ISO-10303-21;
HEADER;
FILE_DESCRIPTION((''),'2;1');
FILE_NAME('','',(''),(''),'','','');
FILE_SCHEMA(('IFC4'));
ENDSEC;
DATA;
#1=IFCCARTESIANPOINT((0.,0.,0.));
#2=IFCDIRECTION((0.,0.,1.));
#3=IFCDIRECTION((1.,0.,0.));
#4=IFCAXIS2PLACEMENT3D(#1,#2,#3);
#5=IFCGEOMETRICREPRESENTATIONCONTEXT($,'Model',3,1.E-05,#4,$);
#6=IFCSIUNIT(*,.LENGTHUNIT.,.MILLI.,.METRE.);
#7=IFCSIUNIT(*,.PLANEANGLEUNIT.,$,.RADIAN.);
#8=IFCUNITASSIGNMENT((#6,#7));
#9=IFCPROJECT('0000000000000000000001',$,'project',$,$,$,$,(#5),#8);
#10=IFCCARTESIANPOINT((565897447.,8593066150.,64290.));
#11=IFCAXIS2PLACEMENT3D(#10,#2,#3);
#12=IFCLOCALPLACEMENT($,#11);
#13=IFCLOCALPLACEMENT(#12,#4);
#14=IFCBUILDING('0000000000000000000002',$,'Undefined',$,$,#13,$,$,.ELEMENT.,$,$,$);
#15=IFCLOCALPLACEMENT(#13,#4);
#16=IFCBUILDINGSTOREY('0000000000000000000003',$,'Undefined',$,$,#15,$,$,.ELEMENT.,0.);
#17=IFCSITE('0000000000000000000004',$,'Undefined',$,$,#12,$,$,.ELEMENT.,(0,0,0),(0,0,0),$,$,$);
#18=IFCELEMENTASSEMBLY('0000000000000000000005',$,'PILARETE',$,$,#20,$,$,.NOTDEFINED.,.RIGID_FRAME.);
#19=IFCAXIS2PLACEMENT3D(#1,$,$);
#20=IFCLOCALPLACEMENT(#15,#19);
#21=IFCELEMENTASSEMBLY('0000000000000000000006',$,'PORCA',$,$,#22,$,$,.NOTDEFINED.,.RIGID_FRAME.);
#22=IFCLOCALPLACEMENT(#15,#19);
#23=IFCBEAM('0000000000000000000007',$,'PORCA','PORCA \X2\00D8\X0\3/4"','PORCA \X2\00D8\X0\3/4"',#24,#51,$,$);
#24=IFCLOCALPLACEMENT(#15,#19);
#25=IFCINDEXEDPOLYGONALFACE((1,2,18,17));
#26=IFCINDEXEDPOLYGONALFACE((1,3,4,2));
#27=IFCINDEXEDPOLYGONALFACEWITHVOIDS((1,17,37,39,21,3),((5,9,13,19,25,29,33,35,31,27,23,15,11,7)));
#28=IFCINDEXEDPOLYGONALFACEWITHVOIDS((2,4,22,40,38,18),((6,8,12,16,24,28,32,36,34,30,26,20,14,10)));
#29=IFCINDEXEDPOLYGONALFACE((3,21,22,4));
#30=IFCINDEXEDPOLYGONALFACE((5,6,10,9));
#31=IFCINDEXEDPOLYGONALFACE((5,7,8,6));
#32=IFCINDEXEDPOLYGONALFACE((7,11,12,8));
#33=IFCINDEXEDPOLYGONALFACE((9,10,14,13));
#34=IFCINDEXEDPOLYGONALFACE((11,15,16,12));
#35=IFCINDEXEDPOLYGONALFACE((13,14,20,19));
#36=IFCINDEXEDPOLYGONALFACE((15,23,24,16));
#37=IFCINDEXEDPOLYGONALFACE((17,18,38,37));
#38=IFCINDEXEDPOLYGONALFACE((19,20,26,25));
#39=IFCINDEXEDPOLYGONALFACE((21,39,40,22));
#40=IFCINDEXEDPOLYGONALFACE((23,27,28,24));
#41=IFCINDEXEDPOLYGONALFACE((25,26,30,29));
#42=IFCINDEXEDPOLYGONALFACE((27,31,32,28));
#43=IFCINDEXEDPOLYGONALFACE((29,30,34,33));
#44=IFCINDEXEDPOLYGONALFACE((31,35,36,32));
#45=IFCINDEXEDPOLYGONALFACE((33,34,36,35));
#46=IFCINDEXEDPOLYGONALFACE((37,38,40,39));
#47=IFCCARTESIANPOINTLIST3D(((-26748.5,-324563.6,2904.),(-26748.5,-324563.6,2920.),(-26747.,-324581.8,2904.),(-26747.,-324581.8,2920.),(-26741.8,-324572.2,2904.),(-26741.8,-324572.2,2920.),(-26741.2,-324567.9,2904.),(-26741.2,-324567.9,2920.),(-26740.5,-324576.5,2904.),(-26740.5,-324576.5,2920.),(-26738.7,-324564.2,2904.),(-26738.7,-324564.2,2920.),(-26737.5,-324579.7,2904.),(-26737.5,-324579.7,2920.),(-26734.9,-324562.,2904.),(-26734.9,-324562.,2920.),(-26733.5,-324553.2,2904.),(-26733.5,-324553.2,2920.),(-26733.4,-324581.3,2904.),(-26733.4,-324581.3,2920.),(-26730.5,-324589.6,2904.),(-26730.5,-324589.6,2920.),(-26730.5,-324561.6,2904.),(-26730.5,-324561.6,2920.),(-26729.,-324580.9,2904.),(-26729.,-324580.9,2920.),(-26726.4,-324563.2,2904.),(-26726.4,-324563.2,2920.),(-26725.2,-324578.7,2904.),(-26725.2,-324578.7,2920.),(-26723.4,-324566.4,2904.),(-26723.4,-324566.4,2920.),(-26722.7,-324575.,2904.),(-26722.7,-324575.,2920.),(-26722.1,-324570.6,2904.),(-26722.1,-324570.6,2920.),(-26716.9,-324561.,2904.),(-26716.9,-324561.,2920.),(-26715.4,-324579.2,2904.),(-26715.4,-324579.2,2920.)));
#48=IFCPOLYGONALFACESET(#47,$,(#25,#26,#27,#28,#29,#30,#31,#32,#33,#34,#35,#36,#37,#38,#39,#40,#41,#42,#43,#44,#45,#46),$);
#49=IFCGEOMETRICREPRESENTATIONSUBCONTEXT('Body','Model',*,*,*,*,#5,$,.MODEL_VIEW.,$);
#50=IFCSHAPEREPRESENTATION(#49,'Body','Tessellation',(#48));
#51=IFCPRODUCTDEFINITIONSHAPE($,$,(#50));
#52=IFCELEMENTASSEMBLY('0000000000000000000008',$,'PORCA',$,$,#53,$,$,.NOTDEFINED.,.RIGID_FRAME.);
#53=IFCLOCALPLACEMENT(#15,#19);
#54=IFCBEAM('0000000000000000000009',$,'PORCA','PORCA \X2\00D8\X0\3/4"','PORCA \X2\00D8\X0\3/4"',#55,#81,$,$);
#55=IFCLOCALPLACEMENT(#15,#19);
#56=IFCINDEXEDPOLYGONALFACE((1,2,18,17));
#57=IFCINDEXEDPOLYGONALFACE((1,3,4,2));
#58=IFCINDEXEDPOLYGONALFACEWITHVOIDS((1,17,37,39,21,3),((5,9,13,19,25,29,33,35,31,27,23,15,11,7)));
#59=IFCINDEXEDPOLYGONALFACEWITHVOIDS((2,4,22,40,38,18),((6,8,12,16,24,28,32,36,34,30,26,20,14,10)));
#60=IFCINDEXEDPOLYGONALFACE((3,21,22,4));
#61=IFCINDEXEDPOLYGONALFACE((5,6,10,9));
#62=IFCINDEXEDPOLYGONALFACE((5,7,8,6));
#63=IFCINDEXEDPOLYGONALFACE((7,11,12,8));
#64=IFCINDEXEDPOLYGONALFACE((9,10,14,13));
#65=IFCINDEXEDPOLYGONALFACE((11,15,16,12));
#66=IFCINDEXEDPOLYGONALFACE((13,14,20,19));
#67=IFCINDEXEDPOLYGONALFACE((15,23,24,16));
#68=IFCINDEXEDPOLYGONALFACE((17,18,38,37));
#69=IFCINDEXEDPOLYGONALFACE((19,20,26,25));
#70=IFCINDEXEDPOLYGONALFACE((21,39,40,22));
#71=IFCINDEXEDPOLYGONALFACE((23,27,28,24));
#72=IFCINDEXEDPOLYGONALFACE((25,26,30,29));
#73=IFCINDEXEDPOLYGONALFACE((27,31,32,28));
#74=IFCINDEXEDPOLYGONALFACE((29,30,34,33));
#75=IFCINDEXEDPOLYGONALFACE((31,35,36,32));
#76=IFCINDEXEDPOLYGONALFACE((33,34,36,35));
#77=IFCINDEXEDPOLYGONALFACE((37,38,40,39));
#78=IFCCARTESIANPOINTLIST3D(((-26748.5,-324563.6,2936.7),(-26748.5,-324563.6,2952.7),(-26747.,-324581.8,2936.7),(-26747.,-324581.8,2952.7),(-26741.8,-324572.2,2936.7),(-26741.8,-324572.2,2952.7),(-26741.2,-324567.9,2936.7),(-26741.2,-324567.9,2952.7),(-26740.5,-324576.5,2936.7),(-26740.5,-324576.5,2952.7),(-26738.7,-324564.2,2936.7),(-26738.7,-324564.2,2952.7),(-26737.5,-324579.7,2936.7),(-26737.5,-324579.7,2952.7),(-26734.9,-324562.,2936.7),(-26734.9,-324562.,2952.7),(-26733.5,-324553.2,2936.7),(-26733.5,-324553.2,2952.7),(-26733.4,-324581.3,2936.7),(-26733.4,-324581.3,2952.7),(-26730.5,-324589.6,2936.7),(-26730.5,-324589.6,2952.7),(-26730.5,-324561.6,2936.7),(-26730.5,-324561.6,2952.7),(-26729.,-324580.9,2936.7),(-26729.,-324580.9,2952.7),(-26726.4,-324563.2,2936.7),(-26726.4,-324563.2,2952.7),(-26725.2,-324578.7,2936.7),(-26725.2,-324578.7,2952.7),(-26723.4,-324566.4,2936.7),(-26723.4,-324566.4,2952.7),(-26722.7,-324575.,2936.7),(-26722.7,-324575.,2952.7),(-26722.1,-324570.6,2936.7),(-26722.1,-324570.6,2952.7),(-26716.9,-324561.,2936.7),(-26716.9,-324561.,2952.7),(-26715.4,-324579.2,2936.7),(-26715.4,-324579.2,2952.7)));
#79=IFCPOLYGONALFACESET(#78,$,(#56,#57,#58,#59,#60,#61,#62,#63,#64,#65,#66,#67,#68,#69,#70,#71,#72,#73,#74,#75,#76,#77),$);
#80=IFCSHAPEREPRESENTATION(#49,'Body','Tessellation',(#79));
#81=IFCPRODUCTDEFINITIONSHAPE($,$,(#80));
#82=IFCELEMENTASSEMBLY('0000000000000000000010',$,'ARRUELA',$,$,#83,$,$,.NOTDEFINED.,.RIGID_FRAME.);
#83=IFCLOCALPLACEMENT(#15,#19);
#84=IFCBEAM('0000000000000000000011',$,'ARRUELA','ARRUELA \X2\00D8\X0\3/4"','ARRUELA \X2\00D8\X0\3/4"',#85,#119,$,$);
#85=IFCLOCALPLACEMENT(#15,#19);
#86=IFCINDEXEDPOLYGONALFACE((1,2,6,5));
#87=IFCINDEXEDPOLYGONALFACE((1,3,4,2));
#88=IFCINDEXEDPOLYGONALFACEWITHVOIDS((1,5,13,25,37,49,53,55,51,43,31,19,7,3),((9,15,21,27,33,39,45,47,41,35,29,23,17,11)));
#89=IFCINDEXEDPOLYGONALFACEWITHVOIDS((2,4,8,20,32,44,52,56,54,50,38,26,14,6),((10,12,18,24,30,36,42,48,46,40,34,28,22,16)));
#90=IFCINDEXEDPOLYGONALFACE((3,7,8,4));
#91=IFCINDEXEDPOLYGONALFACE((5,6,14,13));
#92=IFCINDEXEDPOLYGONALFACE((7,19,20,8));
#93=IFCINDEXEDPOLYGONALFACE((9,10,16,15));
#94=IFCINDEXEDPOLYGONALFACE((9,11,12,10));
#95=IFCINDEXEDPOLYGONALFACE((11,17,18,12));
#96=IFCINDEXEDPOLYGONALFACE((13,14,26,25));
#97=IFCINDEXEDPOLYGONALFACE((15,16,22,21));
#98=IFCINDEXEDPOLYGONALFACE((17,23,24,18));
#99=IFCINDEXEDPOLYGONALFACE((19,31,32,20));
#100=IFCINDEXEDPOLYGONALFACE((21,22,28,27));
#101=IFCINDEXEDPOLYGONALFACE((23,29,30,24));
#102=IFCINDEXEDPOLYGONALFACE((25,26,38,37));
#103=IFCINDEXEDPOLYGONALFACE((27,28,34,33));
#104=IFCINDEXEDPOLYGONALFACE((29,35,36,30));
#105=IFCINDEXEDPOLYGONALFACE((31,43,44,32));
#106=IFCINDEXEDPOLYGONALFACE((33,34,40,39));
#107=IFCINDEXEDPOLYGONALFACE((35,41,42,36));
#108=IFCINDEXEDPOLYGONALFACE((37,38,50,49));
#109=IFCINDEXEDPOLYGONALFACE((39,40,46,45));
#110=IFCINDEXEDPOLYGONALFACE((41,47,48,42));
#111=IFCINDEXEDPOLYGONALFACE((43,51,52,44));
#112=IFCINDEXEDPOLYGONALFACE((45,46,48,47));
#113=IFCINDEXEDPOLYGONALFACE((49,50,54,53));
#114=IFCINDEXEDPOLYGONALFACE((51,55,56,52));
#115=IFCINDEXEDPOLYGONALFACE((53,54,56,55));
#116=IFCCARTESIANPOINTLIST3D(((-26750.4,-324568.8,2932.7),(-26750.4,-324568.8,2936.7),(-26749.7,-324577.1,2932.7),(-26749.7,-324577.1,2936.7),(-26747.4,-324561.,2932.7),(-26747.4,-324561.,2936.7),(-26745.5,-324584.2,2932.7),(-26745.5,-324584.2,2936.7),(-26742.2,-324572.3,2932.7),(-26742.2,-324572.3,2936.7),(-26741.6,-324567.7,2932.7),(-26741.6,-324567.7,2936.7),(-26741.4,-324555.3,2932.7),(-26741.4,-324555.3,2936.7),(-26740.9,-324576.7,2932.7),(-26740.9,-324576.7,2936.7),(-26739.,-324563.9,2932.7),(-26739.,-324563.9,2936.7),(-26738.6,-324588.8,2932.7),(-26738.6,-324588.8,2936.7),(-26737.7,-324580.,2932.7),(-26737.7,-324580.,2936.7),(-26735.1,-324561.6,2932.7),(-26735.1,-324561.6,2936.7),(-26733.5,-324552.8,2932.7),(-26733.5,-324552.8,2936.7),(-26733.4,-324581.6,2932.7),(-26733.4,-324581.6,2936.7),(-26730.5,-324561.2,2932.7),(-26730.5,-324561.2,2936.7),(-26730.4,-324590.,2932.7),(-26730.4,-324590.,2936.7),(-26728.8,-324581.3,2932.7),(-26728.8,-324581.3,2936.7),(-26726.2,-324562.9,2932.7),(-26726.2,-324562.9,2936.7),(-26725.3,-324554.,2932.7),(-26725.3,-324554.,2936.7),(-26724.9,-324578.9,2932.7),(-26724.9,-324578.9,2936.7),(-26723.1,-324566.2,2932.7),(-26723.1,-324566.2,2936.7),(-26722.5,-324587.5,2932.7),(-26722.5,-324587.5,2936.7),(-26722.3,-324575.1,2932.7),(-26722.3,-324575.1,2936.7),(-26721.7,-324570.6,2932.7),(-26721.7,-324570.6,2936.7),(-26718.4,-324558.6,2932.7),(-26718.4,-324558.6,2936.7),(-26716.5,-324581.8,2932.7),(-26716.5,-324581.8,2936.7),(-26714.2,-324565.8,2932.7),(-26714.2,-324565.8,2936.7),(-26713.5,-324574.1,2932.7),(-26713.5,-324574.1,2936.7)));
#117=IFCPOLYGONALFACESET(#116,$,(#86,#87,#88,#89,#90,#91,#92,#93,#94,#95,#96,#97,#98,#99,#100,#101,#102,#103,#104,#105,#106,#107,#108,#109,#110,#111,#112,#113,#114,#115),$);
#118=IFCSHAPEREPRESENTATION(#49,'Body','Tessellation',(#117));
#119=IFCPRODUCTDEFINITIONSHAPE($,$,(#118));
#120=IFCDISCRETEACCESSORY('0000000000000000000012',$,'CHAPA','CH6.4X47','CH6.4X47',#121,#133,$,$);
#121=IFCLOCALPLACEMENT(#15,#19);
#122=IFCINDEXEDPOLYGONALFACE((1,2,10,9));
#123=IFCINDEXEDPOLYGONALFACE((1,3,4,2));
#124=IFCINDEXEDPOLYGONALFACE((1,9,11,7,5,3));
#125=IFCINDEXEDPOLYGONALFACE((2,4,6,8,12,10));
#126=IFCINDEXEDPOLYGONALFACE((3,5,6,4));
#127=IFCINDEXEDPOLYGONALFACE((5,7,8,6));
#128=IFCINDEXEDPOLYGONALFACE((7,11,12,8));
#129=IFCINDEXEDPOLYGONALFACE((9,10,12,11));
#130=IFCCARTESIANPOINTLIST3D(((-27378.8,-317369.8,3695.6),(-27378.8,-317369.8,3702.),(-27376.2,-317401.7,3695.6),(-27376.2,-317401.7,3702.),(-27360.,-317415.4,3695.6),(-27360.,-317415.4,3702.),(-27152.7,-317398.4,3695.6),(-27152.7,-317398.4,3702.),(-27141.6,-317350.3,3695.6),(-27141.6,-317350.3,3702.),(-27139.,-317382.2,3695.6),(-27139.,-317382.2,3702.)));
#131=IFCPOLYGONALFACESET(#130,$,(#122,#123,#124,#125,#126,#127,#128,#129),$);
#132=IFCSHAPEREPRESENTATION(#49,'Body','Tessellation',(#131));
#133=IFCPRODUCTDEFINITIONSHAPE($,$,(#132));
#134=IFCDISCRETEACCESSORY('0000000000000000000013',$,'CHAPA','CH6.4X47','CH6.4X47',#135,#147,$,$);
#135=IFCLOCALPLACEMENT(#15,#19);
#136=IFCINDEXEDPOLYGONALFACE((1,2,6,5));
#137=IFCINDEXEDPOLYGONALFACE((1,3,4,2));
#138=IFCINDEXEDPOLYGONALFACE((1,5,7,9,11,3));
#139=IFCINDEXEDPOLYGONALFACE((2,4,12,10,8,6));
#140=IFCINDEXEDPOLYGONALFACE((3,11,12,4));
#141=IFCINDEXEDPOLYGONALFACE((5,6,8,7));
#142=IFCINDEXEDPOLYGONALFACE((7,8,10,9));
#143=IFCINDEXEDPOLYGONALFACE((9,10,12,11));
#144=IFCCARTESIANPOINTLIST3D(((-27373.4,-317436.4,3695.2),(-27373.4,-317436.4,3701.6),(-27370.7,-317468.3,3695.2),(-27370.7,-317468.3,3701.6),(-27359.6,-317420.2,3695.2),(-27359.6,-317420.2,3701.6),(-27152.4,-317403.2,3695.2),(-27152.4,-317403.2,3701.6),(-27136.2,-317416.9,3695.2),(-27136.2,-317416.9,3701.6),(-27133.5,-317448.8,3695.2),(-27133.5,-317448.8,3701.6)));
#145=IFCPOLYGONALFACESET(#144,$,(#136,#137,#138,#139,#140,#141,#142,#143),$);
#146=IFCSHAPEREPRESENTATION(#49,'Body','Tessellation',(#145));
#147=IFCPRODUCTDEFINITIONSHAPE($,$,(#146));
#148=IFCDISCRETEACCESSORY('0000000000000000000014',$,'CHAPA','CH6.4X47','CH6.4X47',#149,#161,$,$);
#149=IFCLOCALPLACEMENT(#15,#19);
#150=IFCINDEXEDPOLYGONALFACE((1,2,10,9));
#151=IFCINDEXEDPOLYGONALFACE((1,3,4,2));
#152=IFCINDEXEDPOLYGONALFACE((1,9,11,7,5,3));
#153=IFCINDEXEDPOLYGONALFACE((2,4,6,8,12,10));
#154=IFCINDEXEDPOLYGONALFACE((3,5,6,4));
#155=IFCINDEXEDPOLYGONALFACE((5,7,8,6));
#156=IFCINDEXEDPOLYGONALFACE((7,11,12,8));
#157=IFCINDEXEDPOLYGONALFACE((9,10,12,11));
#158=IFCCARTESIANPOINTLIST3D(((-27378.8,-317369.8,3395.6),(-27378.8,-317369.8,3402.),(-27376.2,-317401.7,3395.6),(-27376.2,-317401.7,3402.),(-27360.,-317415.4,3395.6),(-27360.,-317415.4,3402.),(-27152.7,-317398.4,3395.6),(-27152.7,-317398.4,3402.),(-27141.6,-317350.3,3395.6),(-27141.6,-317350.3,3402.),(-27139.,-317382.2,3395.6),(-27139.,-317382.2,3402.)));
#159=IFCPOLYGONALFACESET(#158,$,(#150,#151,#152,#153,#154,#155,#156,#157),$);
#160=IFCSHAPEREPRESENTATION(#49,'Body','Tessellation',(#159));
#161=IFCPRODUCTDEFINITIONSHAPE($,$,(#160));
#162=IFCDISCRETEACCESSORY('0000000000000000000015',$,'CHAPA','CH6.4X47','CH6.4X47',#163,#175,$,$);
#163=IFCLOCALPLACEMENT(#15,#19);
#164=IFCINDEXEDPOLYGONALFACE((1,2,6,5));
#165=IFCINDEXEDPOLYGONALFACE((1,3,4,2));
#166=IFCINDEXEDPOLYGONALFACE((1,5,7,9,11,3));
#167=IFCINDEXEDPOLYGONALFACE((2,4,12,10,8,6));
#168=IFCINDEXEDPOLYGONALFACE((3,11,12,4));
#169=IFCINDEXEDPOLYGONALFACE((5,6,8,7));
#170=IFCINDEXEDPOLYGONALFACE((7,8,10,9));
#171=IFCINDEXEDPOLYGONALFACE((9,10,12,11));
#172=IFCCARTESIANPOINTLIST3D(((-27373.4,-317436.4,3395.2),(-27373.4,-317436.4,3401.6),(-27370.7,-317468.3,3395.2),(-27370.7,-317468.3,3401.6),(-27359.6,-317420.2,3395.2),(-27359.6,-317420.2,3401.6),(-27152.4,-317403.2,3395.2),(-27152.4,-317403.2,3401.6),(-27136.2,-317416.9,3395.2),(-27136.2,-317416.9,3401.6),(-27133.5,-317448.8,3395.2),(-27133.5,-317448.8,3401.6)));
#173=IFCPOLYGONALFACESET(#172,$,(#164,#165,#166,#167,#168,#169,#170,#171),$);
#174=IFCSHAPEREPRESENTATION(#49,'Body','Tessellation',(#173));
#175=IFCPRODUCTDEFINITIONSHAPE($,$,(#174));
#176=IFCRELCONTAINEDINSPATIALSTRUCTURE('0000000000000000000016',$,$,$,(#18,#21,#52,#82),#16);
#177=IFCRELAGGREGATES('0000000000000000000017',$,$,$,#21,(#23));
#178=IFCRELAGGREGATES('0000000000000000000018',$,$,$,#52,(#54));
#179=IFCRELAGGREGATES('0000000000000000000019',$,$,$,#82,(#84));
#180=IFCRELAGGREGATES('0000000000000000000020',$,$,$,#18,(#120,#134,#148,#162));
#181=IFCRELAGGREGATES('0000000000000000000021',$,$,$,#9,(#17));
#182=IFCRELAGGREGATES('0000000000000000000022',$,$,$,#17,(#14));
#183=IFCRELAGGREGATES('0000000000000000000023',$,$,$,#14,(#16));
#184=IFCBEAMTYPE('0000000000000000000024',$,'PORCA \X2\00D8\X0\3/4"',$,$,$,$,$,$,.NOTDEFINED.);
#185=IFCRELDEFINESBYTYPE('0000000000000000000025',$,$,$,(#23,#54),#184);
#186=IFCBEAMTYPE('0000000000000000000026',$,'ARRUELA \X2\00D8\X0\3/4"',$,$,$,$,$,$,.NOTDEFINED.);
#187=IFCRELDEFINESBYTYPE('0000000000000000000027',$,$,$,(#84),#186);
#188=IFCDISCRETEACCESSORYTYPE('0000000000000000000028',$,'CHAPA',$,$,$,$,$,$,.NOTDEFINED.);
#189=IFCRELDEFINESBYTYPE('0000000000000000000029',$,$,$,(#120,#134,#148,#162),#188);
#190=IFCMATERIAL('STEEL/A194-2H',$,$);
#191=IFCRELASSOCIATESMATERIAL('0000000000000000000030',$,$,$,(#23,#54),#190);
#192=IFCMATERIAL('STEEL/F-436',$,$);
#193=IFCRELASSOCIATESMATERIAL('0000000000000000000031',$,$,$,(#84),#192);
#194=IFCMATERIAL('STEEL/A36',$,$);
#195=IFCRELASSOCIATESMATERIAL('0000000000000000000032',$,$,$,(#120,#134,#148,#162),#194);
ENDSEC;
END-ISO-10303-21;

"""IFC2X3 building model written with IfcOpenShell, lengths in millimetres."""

from ifc_helpers import new_model, si_unit, frame, origin_with_axes, place, context, subcontext, project, spatial, polyline, outline, extrude, material, type_object, element, aggregate, save


model = new_model("IFC2X3")

# Units and contexts
model_context = context("Model", 3, precision=1e-05, world=origin_with_axes())
body_context = subcontext(model_context, "Body", "Model", "MODEL_VIEW")
ifc_project = project(units=[si_unit("LENGTHUNIT", "METRE", prefix="MILLI"), si_unit("PLANEANGLEUNIT", "RADIAN")], contexts=[model_context])

# Site, building, storey
site_placement = place(None, frame((565897447.0, 8593066150.0, 64290.0), z_axis=(0.0, 0.0, 1.0), x_axis=(1.0, 0.0, 0.0)))
site = spatial("IfcSite", under=ifc_project, at=site_placement, Name="Undefined", CompositionType="ELEMENT", RefLatitude=(0, 0, 0), RefLongitude=(0, 0, 0))
building_placement = place(site_placement, origin_with_axes())
building = spatial("IfcBuilding", under=site, at=building_placement, Name="Undefined", CompositionType="ELEMENT")
storey_placement = place(building_placement, origin_with_axes())
storey = spatial("IfcBuildingStorey", under=building, at=storey_placement, Name="Undefined", CompositionType="ELEMENT", Elevation=0.0)

# Element assembly
assembly_1_placement = place(storey_placement, origin_with_axes())
assembly_1 = element("IfcElementAssembly", 1, at=assembly_1_placement, inside=storey, Name="PILARETE", AssemblyPlace="NOTDEFINED", PredefinedType="RIGID_FRAME")

# Element assemblies, beams
ifc_material_1 = material(Name="STEEL/A36")
assembly_2_placement = place(storey_placement, origin_with_axes())
assembly_2 = element("IfcElementAssembly", 2, at=assembly_2_placement, inside=storey, Name="PORCA", AssemblyPlace="NOTDEFINED", PredefinedType="RIGID_FRAME")
ifc_material_2 = material(Name="STEEL/A194-2H")
beam_type_1 = type_object("IfcBeamType", Name="PORCA Ø3/4\"", PredefinedType="NOTDEFINED")
beam_1_placement = place(assembly_2_placement, frame((-26732.0, -324571.4, 2920.0), z_axis=(0.99663, 0.082025, 0.0), x_axis=(0.0, 0.0, -1.0)))
beam_1 = element("IfcBeam", 3, at=beam_1_placement, type_object=beam_type_1, material=ifc_material_2, Name="PORCA", Description="PORCA Ø3/4\"", ObjectType="PORCA Ø3/4\"", context=body_context, shape_type="SweptSolid", body=[
    extrude(outline(polyline([(-9.1, 15.8), (9.1, 15.8), (18.3, 0.0), (9.1, -15.8), (-9.1, -15.8), (-18.3, 0.0), (-9.1, 15.8)]), holes=[polyline([(7.8, -6.2), (9.7, -2.2), (9.7, 2.2), (7.8, 6.2), (4.3, 8.9), (0.0, 9.9), (-4.3, 8.9), (-7.8, 6.2), (-9.7, 2.2), (-9.7, -2.2), (-7.8, -6.2), (-4.3, -8.9), (0.0, -9.9), (4.3, -8.9), (7.8, -6.2)])]), frame((16.0, 0.0, 0.0), z_axis=(-1.0, 0.0, 0.0), x_axis=(0.0, -1.0, 0.0)), (0.0, 0.0, 1.0), 16.0),
])
aggregate(assembly_2, [beam_1])
assembly_3_placement = place(storey_placement, origin_with_axes())
assembly_3 = element("IfcElementAssembly", 4, at=assembly_3_placement, inside=storey, Name="PORCA", AssemblyPlace="NOTDEFINED", PredefinedType="RIGID_FRAME")
beam_2_placement = place(assembly_3_placement, frame((-26732.0, -324571.4, 2952.7), z_axis=(0.99663, 0.082025, 0.0), x_axis=(0.0, 0.0, -1.0)))
beam_2 = element("IfcBeam", 5, at=beam_2_placement, type_object=beam_type_1, material=ifc_material_2, Name="PORCA", Description="PORCA Ø3/4\"", ObjectType="PORCA Ø3/4\"", context=body_context, shape_type="SweptSolid", body=[
    extrude(outline(polyline([(-9.1, 15.8), (9.1, 15.8), (18.3, 0.0), (9.1, -15.8), (-9.1, -15.8), (-18.3, 0.0), (-9.1, 15.8)]), holes=[polyline([(7.8, -6.2), (9.7, -2.2), (9.7, 2.2), (7.8, 6.2), (4.3, 8.9), (0.0, 9.9), (-4.3, 8.9), (-7.8, 6.2), (-9.7, 2.2), (-9.7, -2.2), (-7.8, -6.2), (-4.3, -8.9), (0.0, -9.9), (4.3, -8.9), (7.8, -6.2)])]), frame((16.0, 0.0, 0.0), z_axis=(-1.0, 0.0, 0.0), x_axis=(0.0, -1.0, 0.0)), (0.0, 0.0, 1.0), 16.0),
])
aggregate(assembly_3, [beam_2])
assembly_4_placement = place(storey_placement, origin_with_axes())
assembly_4 = element("IfcElementAssembly", 6, at=assembly_4_placement, inside=storey, Name="ARRUELA", AssemblyPlace="NOTDEFINED", PredefinedType="RIGID_FRAME")
ifc_material_3 = material(Name="STEEL/F-436")
beam_type_2 = type_object("IfcBeamType", Name="ARRUELA Ø3/4\"", PredefinedType="NOTDEFINED")
beam_3_placement = place(assembly_4_placement, frame((-26732.0, -324571.4, 2936.7), z_axis=(0.99663, 0.082025, 0.0), x_axis=(0.0, 0.0, -1.0)))
beam_3 = element("IfcBeam", 7, at=beam_3_placement, type_object=beam_type_2, material=ifc_material_3, Name="ARRUELA", Description="ARRUELA Ø3/4\"", ObjectType="ARRUELA Ø3/4\"", context=body_context, shape_type="SweptSolid", body=[
    extrude(outline(polyline([(11.6, 14.6), (16.8, 8.1), (18.6, 0.0), (16.8, -8.1), (11.6, -14.6), (4.2, -18.2), (-4.2, -18.2), (-11.6, -14.6), (-16.8, -8.1), (-18.6, 0.0), (-16.8, 8.1), (-11.6, 14.6), (-4.2, 18.2), (4.2, 18.2), (11.6, 14.6)]), holes=[polyline([(8.1, -6.4), (10.1, -2.3), (10.1, 2.3), (8.1, 6.4), (4.5, 9.3), (0.0, 10.3), (-4.5, 9.3), (-8.1, 6.4), (-10.1, 2.3), (-10.1, -2.3), (-8.1, -6.4), (-4.5, -9.3), (0.0, -10.3), (4.5, -9.3), (8.1, -6.4)])]), frame((4.0, 0.0, 0.0), z_axis=(-1.0, 0.0, 0.0), x_axis=(0.0, -1.0, 0.0)), (0.0, 0.0, 1.0), 4.0),
])
aggregate(assembly_4, [beam_3])

# Shared definitions
discrete_accessory_type_1 = type_object("IfcDiscreteAccessoryType", Name="CHAPA")

# Discrete accessories
discrete_accessory_1_placement = place(assembly_1_placement, frame((-27375.0, -317416.7, 3698.8), z_axis=(0.0, 0.0, -1.0), x_axis=(-0.082025, 0.99663, 0.0)))
discrete_accessory_1 = element("IfcDiscreteAccessory", 8, at=discrete_accessory_1_placement, type_object=discrete_accessory_type_1, material=ifc_material_1, Name="CHAPA", Description="CH6.4X47", ObjectType="CH6.4X47", context=body_context, shape_type="SweptSolid", body=[
    extrude(outline(polyline([(0.0, 15.0), (15.0, 0.0), (47.0, 0.0), (47.0, 238.0), (15.0, 238.0), (0.0, 223.0), (0.0, 15.0)])), frame((0.0, 0.0, -3.2), z_axis=(0.0, 0.0, 1.0), x_axis=(1.0, 0.0, 0.0)), (0.0, 0.0, 1.0), 6.4),
])
discrete_accessory_2_placement = place(assembly_1_placement, frame((-27374.6, -317421.5, 3698.4), z_axis=(0.0, 0.0, 1.0), x_axis=(0.082025, -0.99663, 0.0)))
discrete_accessory_2 = element("IfcDiscreteAccessory", 9, at=discrete_accessory_2_placement, type_object=discrete_accessory_type_1, material=ifc_material_1, Name="CHAPA", Description="CH6.4X47", ObjectType="CH6.4X47", context=body_context, shape_type="SweptSolid", body=[
    extrude(outline(polyline([(0.0, 15.0), (15.0, 0.0), (47.0, 0.0), (47.0, 238.0), (15.0, 238.0), (0.0, 223.0), (0.0, 15.0)])), frame((0.0, 0.0, -3.2), z_axis=(0.0, 0.0, 1.0), x_axis=(1.0, 0.0, 0.0)), (0.0, 0.0, 1.0), 6.4),
])
discrete_accessory_3_placement = place(assembly_1_placement, frame((-27375.0, -317416.7, 3398.8), z_axis=(0.0, 0.0, -1.0), x_axis=(-0.082025, 0.99663, 0.0)))
discrete_accessory_3 = element("IfcDiscreteAccessory", 10, at=discrete_accessory_3_placement, type_object=discrete_accessory_type_1, material=ifc_material_1, Name="CHAPA", Description="CH6.4X47", ObjectType="CH6.4X47", context=body_context, shape_type="SweptSolid", body=[
    extrude(outline(polyline([(0.0, 15.0), (15.0, 0.0), (47.0, 0.0), (47.0, 238.0), (15.0, 238.0), (0.0, 223.0), (0.0, 15.0)])), frame((0.0, 0.0, -3.2), z_axis=(0.0, 0.0, 1.0), x_axis=(1.0, 0.0, 0.0)), (0.0, 0.0, 1.0), 6.4),
])
discrete_accessory_4_placement = place(assembly_1_placement, frame((-27374.6, -317421.5, 3398.4), z_axis=(0.0, 0.0, 1.0), x_axis=(0.082025, -0.99663, 0.0)))
discrete_accessory_4 = element("IfcDiscreteAccessory", 11, at=discrete_accessory_4_placement, type_object=discrete_accessory_type_1, material=ifc_material_1, Name="CHAPA", Description="CH6.4X47", ObjectType="CH6.4X47", context=body_context, shape_type="SweptSolid", body=[
    extrude(outline(polyline([(0.0, 15.0), (15.0, 0.0), (47.0, 0.0), (47.0, 238.0), (15.0, 238.0), (0.0, 223.0), (0.0, 15.0)])), frame((0.0, 0.0, -3.2), z_axis=(0.0, 0.0, 1.0), x_axis=(1.0, 0.0, 0.0)), (0.0, 0.0, 1.0), 6.4),
])

aggregate(assembly_1, [discrete_accessory_1, discrete_accessory_2, discrete_accessory_3, discrete_accessory_4])

save(model, "model.ifc")
